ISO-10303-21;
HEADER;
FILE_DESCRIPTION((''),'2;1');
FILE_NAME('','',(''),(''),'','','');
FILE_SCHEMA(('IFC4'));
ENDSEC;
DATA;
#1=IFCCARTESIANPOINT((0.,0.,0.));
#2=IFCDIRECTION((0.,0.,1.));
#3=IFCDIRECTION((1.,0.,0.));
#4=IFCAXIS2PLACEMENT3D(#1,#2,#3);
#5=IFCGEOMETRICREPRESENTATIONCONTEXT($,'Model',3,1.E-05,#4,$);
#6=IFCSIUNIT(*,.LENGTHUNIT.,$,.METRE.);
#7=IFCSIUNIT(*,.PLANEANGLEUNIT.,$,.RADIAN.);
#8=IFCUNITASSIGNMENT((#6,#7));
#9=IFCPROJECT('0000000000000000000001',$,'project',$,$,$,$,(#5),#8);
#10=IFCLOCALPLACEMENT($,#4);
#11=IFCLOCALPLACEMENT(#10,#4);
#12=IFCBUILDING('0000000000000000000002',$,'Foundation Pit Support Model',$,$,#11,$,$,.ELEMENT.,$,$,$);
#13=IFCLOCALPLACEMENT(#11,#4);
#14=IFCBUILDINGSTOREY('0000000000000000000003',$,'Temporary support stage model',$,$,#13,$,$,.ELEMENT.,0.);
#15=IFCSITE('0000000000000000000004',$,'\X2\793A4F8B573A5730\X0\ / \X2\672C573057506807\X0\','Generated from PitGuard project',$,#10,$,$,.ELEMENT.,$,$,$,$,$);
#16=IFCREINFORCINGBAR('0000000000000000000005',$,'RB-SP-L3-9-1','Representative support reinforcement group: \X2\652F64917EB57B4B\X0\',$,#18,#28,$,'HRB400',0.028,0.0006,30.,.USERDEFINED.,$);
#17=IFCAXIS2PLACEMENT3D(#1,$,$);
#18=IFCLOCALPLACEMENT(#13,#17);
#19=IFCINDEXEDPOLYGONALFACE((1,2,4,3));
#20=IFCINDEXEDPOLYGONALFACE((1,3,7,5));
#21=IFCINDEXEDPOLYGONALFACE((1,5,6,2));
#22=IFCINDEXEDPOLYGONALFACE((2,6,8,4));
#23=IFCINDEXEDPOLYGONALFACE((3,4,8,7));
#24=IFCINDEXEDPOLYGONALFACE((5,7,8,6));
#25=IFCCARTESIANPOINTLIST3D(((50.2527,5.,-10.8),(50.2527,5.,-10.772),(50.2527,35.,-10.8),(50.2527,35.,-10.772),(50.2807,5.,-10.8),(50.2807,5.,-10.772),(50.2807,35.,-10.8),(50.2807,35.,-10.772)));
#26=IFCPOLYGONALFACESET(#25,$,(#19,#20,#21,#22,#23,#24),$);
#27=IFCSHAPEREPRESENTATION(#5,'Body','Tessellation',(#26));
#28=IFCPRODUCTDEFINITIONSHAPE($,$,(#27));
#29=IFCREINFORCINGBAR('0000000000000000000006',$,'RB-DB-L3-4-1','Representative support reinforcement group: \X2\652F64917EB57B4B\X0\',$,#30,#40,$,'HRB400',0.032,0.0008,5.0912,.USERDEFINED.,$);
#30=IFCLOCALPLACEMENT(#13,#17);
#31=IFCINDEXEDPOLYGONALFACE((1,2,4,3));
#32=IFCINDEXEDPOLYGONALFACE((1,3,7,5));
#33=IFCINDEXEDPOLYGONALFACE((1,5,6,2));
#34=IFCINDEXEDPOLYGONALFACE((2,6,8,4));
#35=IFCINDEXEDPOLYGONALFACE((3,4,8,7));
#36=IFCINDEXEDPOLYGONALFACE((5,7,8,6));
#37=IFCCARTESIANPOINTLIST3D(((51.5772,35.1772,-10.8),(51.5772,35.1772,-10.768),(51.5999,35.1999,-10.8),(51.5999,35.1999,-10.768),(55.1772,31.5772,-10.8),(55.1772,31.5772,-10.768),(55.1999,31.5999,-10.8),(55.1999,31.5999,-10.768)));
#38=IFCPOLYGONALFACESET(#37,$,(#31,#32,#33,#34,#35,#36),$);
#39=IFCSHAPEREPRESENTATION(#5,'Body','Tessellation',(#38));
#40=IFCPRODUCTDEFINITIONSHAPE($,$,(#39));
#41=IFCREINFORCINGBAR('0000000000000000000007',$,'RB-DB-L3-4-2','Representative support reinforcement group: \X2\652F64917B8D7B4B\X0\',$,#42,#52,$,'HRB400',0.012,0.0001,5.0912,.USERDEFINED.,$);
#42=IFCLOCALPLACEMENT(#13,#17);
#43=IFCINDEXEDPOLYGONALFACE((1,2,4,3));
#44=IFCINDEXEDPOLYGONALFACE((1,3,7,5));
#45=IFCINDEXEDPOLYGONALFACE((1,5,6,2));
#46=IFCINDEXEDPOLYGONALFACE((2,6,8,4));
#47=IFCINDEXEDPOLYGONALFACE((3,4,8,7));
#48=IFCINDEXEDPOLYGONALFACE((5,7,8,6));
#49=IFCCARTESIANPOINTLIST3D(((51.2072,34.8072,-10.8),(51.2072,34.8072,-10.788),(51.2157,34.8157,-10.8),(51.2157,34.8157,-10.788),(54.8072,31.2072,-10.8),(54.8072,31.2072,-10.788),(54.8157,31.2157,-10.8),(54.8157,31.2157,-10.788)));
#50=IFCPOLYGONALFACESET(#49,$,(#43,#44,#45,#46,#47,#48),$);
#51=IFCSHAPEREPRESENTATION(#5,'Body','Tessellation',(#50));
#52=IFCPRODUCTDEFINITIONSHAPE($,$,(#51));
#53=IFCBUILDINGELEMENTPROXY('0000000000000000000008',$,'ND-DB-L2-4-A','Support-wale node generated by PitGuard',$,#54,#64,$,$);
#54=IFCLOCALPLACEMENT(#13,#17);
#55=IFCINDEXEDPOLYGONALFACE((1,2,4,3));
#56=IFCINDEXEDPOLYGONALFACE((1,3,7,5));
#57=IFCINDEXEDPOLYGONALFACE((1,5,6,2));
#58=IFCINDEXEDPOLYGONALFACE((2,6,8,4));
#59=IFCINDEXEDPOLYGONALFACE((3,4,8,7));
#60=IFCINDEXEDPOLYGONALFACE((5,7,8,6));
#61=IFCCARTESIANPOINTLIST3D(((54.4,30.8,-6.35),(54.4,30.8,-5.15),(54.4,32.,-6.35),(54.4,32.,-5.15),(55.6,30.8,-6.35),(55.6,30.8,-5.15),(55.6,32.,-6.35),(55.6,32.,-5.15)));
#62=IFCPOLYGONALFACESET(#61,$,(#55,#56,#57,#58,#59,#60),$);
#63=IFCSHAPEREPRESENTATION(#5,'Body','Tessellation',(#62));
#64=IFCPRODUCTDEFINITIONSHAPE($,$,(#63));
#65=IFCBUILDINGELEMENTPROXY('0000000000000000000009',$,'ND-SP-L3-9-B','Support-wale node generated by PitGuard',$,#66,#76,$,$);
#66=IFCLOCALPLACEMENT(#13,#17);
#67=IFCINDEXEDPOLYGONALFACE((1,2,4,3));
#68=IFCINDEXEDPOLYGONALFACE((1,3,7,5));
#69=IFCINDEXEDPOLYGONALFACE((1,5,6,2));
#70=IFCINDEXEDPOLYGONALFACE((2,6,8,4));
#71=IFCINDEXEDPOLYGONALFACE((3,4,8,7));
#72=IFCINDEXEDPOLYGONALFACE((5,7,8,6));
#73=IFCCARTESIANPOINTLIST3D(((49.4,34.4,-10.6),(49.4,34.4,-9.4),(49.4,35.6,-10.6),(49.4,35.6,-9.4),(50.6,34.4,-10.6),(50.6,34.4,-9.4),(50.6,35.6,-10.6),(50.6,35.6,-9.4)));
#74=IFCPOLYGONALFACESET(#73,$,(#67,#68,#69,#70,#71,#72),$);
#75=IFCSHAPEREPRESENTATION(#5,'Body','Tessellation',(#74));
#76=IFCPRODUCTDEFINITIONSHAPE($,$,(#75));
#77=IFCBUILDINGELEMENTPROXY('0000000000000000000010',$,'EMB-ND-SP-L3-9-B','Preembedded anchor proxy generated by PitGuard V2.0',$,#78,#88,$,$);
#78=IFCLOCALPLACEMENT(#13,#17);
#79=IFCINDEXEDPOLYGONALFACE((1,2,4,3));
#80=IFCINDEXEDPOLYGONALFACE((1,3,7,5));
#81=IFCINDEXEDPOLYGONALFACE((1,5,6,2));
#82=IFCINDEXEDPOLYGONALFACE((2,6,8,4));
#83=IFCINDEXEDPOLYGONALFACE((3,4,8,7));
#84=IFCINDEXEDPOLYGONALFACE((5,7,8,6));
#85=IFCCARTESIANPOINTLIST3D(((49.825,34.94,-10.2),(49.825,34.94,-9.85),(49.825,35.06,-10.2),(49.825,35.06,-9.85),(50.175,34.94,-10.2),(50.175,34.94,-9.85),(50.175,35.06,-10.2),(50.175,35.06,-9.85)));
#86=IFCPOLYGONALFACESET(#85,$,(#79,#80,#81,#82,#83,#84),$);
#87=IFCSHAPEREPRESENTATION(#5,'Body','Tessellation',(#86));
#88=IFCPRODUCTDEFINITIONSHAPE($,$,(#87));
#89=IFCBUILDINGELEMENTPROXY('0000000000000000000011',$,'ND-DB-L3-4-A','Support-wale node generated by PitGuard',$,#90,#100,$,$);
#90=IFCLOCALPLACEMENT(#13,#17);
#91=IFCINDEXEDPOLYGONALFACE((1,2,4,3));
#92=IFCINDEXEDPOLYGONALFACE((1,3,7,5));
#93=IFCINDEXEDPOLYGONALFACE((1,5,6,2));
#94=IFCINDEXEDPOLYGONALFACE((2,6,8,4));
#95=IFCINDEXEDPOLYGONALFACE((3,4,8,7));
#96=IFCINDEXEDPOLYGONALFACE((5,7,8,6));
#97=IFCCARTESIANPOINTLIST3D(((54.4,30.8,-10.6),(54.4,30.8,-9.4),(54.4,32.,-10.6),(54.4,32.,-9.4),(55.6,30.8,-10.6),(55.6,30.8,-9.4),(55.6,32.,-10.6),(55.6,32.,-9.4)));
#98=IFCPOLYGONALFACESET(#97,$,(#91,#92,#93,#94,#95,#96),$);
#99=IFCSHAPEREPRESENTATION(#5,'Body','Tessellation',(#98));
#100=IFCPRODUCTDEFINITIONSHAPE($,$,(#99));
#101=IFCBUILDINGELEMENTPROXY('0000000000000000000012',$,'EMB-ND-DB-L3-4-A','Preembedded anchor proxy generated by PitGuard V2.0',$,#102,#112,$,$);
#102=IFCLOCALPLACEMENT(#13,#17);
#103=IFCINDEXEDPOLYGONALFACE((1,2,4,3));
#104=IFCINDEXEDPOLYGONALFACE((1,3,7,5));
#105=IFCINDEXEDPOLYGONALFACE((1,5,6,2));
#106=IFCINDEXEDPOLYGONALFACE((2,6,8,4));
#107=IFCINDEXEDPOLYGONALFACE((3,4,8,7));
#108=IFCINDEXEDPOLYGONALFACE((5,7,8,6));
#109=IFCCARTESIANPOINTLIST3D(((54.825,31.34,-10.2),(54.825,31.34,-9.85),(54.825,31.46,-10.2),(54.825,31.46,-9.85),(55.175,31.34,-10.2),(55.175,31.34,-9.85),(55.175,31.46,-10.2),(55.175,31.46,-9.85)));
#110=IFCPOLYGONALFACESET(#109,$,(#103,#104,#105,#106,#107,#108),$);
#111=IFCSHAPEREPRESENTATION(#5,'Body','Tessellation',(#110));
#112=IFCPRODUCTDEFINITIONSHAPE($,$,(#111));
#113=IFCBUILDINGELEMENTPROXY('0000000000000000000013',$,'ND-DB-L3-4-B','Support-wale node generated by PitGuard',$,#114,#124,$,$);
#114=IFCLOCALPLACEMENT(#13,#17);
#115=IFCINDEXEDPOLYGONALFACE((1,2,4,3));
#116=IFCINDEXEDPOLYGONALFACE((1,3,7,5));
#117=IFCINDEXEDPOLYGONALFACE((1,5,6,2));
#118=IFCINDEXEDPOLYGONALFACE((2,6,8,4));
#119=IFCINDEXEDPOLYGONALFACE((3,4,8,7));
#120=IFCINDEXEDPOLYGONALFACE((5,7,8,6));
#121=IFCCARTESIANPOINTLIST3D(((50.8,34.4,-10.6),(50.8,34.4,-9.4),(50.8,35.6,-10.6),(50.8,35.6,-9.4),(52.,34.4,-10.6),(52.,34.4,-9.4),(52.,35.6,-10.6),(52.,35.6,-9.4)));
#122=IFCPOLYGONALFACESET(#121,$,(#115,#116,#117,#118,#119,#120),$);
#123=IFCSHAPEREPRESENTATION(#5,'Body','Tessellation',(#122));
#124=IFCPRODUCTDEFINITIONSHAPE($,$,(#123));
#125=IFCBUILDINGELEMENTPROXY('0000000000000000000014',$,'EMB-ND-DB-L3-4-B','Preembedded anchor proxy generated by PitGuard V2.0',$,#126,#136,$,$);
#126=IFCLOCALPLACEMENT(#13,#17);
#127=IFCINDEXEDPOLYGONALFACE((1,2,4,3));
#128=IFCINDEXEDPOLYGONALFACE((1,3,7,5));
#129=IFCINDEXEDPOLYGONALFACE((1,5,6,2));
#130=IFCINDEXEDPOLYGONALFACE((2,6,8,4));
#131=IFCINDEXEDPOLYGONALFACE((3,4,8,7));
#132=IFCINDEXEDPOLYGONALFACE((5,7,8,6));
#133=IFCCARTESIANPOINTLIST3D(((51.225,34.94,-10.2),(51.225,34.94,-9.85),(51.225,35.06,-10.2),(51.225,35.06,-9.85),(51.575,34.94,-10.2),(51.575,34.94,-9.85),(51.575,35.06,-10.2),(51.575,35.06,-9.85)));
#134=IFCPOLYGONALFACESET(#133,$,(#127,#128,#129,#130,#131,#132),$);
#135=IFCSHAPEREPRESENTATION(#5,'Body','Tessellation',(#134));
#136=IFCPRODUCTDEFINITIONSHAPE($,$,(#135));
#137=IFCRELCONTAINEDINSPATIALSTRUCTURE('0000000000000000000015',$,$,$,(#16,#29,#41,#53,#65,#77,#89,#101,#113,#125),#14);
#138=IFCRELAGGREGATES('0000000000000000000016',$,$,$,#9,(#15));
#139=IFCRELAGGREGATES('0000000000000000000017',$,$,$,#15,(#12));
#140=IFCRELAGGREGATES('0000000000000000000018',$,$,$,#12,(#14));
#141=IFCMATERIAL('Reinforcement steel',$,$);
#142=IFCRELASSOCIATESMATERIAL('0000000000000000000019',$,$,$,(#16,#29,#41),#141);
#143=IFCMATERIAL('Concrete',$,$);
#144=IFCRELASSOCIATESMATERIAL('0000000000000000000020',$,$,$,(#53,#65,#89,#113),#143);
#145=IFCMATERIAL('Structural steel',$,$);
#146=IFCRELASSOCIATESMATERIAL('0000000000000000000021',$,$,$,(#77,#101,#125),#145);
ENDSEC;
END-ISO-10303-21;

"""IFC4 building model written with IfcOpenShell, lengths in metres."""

from ifc_helpers import new_model, si_unit, frame, origin_with_axes, origin_2d, place, context, project, spatial, rectangle, extrude, material, element, save


model = new_model("IFC4")

# Units and contexts
model_context = context("Model", 3, precision=1e-05, world=origin_with_axes())
ifc_project = project(units=[si_unit("LENGTHUNIT", "METRE"), si_unit("PLANEANGLEUNIT", "RADIAN")], contexts=[model_context])

# Site, building, storey
site_placement = place(None, origin_with_axes())
site = spatial("IfcSite", under=ifc_project, at=site_placement, Name="示例场地 / 本地坐标", Description="Generated from PitGuard project", CompositionType="ELEMENT")
building_placement = place(site_placement, origin_with_axes())
building = spatial("IfcBuilding", under=site, at=building_placement, Name="Foundation Pit Support Model", CompositionType="ELEMENT")
storey_placement = place(building_placement, origin_with_axes())
storey = spatial("IfcBuildingStorey", under=building, at=storey_placement, Name="Temporary support stage model", CompositionType="ELEMENT", Elevation=0.0)

# Shared definitions
ifc_material_1 = material(Name="Concrete")

# Shared definitions
ifc_material_2 = material(Name="Structural steel")

# Reinforcing bars
ifc_material_3 = material(Name="Reinforcement steel")
reinforcing_bar_1_placement = place(storey_placement, frame((50.2667, 20.0, -10.8), z_axis=(0.0, 0.0, 1.0), x_axis=(0.0, 1.0, 0.0)))
element("IfcReinforcingBar", 1, at=reinforcing_bar_1_placement, inside=storey, material=ifc_material_3, Name="RB-SP-L3-9-1", Description="Representative support reinforcement group: 支撑纵筋", SteelGrade="HRB400", BarLength=30.0, CrossSectionArea=0.0006, NominalDiameter=0.028, PredefinedType="USERDEFINED", context=model_context, shape_type="SweptSolid", body=[
    extrude(rectangle(XDim=30.0, YDim=0.028, at=origin_2d()), origin_with_axes(), (0.0, 0.0, 1.0), 0.028),
])
reinforcing_bar_2_placement = place(storey_placement, frame((53.3886, 33.3886, -10.8), z_axis=(0.0, 0.0, 1.0), x_axis=(-0.707107, 0.707107, 0.0)))
element("IfcReinforcingBar", 2, at=reinforcing_bar_2_placement, inside=storey, material=ifc_material_3, Name="RB-DB-L3-4-1", Description="Representative support reinforcement group: 支撑纵筋", SteelGrade="HRB400", BarLength=5.0912, CrossSectionArea=0.0008, NominalDiameter=0.032, PredefinedType="USERDEFINED", context=model_context, shape_type="SweptSolid", body=[
    extrude(rectangle(XDim=5.0912, YDim=0.032, at=origin_2d()), origin_with_axes(), (0.0, 0.0, 1.0), 0.032),
])
reinforcing_bar_3_placement = place(storey_placement, frame((53.0114, 33.0114, -10.8), z_axis=(0.0, 0.0, 1.0), x_axis=(-0.707107, 0.707107, 0.0)))
element("IfcReinforcingBar", 3, at=reinforcing_bar_3_placement, inside=storey, material=ifc_material_3, Name="RB-DB-L3-4-2", Description="Representative support reinforcement group: 支撑箍筋", SteelGrade="HRB400", BarLength=5.0912, CrossSectionArea=0.0001, NominalDiameter=0.012, PredefinedType="USERDEFINED", context=model_context, shape_type="SweptSolid", body=[
    extrude(rectangle(XDim=5.0912, YDim=0.012, at=origin_2d()), origin_with_axes(), (0.0, 0.0, 1.0), 0.012),
])

# Building element proxies
for number, where, z_axis, x_axis, name in (
    (4, (55.0, 31.4, -6.35), (0.0, 0.0, 1.0), (1.0, 0.0, 0.0), "ND-DB-L2-4-A"),
    (5, (50.0, 35.0, -10.6), (0.0, 0.0, 1.0), (1.0, 0.0, 0.0), "ND-SP-L3-9-B"),
):
    element("IfcBuildingElementProxy", number, at=place(storey_placement, frame(where, z_axis=z_axis, x_axis=x_axis)), inside=storey, material=ifc_material_1, Name=name, Description="Support-wale node generated by PitGuard", context=model_context, shape_type="SweptSolid", body=[
        extrude(rectangle(XDim=1.2, YDim=1.2, at=origin_2d()), origin_with_axes(), (0.0, 0.0, 1.0), 1.2),
    ])
proxy_1_placement = place(storey_placement, frame((50.0, 35.0, -10.2), z_axis=(0.0, 0.0, 1.0), x_axis=(1.0, 0.0, 0.0)))
element("IfcBuildingElementProxy", 6, at=proxy_1_placement, inside=storey, material=ifc_material_2, Name="EMB-ND-SP-L3-9-B", Description="Preembedded anchor proxy generated by PitGuard V2.0", context=model_context, shape_type="SweptSolid", body=[
    extrude(rectangle(XDim=0.35, YDim=0.12, at=origin_2d()), origin_with_axes(), (0.0, 0.0, 1.0), 0.35),
])
proxy_2_placement = place(storey_placement, frame((55.0, 31.4, -10.6), z_axis=(0.0, 0.0, 1.0), x_axis=(1.0, 0.0, 0.0)))
element("IfcBuildingElementProxy", 7, at=proxy_2_placement, inside=storey, material=ifc_material_1, Name="ND-DB-L3-4-A", Description="Support-wale node generated by PitGuard", context=model_context, shape_type="SweptSolid", body=[
    extrude(rectangle(XDim=1.2, YDim=1.2, at=origin_2d()), origin_with_axes(), (0.0, 0.0, 1.0), 1.2),
])
proxy_3_placement = place(storey_placement, frame((55.0, 31.4, -10.2), z_axis=(0.0, 0.0, 1.0), x_axis=(1.0, 0.0, 0.0)))
element("IfcBuildingElementProxy", 8, at=proxy_3_placement, inside=storey, material=ifc_material_2, Name="EMB-ND-DB-L3-4-A", Description="Preembedded anchor proxy generated by PitGuard V2.0", context=model_context, shape_type="SweptSolid", body=[
    extrude(rectangle(XDim=0.35, YDim=0.12, at=origin_2d()), origin_with_axes(), (0.0, 0.0, 1.0), 0.35),
])
proxy_4_placement = place(storey_placement, frame((51.4, 35.0, -10.6), z_axis=(0.0, 0.0, 1.0), x_axis=(1.0, 0.0, 0.0)))
element("IfcBuildingElementProxy", 9, at=proxy_4_placement, inside=storey, material=ifc_material_1, Name="ND-DB-L3-4-B", Description="Support-wale node generated by PitGuard", context=model_context, shape_type="SweptSolid", body=[
    extrude(rectangle(XDim=1.2, YDim=1.2, at=origin_2d()), origin_with_axes(), (0.0, 0.0, 1.0), 1.2),
])
proxy_5_placement = place(storey_placement, frame((51.4, 35.0, -10.2), z_axis=(0.0, 0.0, 1.0), x_axis=(1.0, 0.0, 0.0)))
element("IfcBuildingElementProxy", 10, at=proxy_5_placement, inside=storey, material=ifc_material_2, Name="EMB-ND-DB-L3-4-B", Description="Preembedded anchor proxy generated by PitGuard V2.0", context=model_context, shape_type="SweptSolid", body=[
    extrude(rectangle(XDim=0.35, YDim=0.12, at=origin_2d()), origin_with_axes(), (0.0, 0.0, 1.0), 0.35),
])

save(model, "model.ifc")
